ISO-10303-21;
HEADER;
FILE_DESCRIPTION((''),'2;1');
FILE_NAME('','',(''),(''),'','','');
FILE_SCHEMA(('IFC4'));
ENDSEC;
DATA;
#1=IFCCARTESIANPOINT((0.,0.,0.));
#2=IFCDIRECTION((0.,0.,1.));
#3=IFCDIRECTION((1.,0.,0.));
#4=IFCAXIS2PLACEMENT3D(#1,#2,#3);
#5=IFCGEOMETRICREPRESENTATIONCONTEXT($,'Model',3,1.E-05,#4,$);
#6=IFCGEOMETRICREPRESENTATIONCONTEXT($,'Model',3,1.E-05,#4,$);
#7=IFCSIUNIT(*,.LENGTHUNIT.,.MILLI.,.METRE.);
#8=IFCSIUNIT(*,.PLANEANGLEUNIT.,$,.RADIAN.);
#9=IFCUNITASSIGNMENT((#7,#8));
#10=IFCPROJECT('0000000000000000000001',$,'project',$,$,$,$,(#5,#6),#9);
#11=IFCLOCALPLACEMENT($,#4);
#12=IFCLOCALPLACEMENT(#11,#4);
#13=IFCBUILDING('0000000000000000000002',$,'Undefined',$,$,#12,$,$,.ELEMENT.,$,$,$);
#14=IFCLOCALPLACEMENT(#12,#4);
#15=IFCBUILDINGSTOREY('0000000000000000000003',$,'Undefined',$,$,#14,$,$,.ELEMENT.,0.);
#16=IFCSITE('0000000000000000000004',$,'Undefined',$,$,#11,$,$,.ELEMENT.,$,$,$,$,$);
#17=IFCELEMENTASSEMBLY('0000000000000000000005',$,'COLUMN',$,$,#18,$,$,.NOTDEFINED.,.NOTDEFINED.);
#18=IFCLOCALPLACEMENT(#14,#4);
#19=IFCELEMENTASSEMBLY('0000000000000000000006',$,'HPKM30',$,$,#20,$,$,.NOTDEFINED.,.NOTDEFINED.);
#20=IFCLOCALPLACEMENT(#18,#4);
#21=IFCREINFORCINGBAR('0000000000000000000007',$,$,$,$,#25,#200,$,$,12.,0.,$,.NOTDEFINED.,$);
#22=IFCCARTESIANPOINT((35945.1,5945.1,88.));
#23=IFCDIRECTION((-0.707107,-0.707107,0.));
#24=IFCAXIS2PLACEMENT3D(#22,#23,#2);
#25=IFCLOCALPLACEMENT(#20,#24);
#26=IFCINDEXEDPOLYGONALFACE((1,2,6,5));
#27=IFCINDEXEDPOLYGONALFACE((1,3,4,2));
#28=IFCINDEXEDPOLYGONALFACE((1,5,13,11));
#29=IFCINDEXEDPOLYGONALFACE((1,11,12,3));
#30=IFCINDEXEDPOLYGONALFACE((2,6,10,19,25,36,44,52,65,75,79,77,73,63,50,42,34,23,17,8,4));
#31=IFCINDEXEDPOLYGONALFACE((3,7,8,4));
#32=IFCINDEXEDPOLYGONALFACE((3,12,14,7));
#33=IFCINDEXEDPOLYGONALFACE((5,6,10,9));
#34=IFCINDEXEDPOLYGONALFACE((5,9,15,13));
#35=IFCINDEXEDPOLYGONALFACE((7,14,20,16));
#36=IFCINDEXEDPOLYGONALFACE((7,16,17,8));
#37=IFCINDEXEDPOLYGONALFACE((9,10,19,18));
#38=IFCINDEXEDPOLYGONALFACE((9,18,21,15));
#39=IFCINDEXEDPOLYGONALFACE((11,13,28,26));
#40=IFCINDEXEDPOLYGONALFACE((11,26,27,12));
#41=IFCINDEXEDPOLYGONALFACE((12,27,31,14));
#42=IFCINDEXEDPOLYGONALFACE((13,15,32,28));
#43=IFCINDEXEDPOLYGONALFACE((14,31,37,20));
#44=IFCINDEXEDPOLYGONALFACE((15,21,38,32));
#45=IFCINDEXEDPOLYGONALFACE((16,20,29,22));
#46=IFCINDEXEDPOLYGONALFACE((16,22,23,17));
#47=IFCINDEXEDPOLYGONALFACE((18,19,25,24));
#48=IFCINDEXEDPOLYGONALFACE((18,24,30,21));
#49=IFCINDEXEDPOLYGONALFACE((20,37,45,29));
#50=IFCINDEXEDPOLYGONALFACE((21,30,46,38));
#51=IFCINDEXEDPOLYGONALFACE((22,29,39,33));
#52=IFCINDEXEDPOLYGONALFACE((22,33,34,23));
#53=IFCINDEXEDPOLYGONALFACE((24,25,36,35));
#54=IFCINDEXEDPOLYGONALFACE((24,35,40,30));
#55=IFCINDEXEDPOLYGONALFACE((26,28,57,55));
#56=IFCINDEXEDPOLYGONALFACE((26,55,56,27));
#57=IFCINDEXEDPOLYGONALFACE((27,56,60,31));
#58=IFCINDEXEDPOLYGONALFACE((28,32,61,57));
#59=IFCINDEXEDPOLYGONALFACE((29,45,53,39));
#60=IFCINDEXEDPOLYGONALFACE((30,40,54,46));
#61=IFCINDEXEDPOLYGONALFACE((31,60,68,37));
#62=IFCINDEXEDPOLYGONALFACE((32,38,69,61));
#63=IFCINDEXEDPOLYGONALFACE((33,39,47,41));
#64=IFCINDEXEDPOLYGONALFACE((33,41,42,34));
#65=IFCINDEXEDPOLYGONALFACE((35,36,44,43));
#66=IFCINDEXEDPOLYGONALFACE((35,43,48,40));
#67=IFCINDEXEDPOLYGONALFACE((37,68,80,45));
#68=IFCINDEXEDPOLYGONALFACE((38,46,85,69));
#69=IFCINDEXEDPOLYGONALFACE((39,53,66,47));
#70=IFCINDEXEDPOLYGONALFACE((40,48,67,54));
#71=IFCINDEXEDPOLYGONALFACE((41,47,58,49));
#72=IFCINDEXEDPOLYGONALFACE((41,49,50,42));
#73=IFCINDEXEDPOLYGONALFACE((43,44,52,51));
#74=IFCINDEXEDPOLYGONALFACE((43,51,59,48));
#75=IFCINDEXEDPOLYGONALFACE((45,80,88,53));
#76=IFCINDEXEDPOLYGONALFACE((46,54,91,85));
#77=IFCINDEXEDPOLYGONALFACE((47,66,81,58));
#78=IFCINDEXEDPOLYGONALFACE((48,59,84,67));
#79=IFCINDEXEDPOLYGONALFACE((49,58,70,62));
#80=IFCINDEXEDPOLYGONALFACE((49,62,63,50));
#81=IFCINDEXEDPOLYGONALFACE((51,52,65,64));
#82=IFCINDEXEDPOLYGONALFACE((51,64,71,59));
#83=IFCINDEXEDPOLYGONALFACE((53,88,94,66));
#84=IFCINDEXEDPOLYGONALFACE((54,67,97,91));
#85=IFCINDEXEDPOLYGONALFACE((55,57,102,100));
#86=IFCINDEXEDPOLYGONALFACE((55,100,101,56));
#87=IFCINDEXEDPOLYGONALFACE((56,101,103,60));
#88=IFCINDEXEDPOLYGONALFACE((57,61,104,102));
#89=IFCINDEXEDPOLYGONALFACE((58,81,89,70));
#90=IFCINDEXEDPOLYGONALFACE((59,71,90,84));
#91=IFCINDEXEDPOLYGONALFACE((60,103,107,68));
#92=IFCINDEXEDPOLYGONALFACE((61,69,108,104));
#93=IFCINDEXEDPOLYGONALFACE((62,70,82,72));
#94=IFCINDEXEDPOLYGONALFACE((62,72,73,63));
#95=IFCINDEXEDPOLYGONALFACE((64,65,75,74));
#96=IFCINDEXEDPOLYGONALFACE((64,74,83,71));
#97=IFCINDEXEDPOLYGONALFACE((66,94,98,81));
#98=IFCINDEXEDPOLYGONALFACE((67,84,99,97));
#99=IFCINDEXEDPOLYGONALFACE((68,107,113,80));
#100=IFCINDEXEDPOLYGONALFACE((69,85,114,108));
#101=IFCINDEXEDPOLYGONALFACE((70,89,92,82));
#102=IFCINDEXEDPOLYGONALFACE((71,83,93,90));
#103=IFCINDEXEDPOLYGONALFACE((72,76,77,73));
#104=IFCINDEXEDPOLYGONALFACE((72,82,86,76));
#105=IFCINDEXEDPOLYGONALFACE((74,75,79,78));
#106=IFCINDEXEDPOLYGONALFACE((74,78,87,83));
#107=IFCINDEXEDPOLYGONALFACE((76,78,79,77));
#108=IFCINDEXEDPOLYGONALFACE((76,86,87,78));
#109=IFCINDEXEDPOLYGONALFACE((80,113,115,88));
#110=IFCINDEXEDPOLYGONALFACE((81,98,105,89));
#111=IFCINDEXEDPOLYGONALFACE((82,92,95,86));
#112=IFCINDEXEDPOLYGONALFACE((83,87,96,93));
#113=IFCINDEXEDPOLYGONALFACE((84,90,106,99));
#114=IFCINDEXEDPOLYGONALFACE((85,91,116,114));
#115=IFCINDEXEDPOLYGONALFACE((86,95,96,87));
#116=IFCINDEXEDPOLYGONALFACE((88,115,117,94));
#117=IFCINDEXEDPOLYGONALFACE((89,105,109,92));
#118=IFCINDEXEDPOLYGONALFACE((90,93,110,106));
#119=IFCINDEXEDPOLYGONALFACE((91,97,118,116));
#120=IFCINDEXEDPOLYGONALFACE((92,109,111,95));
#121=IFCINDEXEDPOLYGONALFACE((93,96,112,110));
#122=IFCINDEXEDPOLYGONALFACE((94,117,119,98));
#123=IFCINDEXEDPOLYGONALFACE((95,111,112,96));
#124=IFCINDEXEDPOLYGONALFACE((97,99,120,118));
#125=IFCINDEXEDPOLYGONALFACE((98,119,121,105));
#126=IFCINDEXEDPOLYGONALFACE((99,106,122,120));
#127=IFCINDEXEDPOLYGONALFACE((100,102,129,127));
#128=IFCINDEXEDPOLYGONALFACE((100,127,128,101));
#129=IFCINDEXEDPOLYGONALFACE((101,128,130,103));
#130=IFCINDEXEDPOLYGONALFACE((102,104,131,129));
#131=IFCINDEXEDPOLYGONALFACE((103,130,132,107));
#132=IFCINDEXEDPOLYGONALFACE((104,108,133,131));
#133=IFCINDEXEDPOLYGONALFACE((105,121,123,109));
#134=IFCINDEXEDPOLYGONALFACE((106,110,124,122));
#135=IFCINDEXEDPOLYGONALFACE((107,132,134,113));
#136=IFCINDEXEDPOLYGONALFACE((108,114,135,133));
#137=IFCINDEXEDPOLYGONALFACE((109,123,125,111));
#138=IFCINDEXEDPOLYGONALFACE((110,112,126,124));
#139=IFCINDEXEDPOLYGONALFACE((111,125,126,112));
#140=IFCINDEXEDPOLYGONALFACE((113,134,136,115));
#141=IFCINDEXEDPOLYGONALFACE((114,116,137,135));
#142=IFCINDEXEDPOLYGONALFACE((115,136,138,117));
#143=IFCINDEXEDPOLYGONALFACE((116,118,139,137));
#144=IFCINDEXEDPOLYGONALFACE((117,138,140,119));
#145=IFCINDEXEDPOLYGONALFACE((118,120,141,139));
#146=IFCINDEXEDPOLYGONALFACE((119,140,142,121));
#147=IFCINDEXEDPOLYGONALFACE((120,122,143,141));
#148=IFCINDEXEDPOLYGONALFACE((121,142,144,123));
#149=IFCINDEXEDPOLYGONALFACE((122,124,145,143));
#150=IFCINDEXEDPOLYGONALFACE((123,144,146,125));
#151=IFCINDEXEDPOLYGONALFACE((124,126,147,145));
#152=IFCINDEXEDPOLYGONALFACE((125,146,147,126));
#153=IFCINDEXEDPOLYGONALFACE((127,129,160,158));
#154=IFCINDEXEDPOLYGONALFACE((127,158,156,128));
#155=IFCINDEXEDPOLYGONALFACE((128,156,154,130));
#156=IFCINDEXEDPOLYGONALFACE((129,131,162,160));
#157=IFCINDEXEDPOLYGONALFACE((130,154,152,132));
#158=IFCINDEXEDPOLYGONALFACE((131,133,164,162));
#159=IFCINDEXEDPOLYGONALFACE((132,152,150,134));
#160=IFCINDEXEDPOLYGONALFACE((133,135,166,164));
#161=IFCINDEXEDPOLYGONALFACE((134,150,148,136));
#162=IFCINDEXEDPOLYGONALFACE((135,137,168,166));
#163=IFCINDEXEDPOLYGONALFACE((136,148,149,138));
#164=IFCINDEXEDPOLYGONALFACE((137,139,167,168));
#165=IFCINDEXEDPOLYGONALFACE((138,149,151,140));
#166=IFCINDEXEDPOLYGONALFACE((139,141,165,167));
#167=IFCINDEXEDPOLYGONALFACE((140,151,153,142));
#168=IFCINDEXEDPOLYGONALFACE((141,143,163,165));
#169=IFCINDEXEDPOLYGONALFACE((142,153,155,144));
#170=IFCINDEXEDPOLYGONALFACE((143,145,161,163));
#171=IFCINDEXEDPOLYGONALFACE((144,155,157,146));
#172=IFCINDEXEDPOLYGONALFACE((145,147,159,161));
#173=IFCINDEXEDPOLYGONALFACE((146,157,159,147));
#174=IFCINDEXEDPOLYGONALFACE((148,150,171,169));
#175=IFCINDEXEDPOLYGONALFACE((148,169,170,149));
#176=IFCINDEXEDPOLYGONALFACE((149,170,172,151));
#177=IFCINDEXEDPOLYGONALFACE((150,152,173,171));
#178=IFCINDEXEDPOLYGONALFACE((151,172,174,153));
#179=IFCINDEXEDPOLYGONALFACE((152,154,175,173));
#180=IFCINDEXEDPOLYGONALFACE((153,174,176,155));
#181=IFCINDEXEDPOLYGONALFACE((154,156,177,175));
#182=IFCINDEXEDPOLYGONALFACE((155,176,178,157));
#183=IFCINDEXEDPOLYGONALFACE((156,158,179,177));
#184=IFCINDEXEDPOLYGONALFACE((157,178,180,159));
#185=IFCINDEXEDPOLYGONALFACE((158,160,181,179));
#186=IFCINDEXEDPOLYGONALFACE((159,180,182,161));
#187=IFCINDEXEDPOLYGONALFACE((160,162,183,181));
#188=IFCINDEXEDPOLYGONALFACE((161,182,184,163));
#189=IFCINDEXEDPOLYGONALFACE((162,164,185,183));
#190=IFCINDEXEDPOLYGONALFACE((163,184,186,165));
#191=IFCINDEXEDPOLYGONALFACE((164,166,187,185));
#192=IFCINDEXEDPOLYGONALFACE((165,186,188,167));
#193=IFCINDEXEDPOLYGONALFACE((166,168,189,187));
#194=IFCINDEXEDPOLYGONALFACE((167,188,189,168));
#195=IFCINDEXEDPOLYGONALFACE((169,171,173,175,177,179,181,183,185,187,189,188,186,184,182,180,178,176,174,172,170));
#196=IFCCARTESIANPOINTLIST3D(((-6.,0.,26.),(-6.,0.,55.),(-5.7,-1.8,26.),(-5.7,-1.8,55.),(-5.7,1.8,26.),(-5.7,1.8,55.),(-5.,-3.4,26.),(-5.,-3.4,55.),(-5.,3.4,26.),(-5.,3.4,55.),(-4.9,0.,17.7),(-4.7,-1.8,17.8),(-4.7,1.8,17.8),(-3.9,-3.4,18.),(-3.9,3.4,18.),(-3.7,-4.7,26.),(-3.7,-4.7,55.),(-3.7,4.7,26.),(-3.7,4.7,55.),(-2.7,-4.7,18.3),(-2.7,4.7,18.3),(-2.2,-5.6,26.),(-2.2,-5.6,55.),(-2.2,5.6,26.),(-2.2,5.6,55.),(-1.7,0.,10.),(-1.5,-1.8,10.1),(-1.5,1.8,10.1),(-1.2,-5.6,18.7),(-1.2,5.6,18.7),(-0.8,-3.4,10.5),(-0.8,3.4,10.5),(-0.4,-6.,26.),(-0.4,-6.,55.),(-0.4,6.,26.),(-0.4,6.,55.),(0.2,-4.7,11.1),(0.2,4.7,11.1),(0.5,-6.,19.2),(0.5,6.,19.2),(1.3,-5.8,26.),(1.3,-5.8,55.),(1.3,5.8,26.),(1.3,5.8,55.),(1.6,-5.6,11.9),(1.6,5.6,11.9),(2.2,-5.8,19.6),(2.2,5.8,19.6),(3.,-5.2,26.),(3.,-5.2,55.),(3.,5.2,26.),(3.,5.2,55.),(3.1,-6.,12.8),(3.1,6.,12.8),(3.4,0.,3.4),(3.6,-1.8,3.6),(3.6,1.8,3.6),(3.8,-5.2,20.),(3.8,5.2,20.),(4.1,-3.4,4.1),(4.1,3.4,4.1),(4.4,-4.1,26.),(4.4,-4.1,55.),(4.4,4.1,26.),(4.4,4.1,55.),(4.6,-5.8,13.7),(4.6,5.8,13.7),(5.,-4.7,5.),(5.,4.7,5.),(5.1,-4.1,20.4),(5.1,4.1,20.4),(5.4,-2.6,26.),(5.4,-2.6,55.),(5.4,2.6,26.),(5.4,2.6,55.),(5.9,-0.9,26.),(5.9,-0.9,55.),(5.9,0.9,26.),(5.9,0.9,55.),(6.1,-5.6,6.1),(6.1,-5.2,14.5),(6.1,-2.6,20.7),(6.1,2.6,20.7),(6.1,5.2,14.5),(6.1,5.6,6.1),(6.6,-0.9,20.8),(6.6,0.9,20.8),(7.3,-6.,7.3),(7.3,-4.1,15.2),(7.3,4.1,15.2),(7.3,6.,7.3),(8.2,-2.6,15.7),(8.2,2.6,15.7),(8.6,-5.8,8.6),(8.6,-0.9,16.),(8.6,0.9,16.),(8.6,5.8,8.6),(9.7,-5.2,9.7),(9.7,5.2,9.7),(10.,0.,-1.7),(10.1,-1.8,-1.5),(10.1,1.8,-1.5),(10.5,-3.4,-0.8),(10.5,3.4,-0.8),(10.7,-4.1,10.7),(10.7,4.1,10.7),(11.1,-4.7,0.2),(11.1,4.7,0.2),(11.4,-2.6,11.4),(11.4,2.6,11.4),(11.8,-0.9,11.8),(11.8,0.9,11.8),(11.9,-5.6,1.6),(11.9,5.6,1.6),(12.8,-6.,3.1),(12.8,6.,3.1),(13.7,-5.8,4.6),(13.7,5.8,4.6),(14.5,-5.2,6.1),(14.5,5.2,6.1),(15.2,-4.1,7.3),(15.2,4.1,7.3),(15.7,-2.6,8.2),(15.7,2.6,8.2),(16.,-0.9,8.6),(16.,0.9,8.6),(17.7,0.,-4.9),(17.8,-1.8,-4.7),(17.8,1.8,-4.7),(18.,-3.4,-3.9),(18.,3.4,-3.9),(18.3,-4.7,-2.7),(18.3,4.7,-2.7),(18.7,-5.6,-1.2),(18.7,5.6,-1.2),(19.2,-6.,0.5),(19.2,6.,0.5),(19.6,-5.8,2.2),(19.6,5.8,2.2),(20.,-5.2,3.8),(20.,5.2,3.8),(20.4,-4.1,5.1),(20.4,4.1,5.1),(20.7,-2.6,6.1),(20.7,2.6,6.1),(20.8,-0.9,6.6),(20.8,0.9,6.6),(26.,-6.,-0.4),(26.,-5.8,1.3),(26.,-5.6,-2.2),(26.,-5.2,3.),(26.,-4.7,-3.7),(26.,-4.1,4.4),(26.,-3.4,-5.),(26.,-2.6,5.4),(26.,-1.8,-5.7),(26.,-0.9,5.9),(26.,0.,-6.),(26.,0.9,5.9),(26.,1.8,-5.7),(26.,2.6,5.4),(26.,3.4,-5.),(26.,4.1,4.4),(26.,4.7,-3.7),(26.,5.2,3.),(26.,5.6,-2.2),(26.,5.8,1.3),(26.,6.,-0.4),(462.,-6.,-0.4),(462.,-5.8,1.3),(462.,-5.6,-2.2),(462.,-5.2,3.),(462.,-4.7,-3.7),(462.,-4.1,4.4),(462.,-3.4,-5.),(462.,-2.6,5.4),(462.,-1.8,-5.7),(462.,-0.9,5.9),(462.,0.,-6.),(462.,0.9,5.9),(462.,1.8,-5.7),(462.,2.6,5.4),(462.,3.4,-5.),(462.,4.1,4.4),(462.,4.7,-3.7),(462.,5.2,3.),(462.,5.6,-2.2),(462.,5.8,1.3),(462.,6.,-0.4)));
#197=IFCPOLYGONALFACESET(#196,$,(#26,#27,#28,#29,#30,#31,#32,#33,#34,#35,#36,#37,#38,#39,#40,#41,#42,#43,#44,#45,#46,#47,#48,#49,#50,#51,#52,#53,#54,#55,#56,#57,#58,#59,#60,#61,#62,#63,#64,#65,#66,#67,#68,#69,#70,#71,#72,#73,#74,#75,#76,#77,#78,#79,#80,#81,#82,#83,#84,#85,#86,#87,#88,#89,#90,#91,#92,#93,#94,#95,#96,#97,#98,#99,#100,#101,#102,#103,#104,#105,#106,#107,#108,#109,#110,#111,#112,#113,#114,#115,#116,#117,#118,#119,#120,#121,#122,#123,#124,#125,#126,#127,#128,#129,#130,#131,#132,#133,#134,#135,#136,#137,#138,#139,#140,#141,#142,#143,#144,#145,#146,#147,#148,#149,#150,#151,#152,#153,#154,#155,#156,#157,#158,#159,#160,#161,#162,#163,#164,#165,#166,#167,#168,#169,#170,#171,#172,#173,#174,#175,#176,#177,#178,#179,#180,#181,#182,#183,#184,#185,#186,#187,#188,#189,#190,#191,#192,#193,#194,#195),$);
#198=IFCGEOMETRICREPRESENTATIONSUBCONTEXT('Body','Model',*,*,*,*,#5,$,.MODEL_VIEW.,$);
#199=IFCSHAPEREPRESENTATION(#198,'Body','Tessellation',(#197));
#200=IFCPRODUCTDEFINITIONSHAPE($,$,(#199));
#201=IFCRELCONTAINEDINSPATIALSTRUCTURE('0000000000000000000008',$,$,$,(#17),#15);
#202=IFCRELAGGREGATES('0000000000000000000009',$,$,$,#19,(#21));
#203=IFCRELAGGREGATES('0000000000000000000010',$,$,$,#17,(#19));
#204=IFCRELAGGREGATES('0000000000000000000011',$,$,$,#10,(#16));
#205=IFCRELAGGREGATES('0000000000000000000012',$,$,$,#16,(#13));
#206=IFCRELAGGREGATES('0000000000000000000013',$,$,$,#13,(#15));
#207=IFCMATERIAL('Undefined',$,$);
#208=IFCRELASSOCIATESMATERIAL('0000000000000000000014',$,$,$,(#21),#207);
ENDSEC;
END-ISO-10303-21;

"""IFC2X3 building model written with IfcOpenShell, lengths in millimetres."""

from ifc_helpers import new_model, entity, si_unit, frame, origin_with_axes, place, context, subcontext, project, spatial, source, transform, mapped, material, element, aggregate, save


model = new_model("IFC2X3")

# Units and contexts
model_context_1 = context("Model", 3, precision=1e-05, world=origin_with_axes())
model_context_2 = context("Model", 3, precision=1e-05, world=origin_with_axes())
body_context = subcontext(model_context_1, "Body", "Model", "MODEL_VIEW")
ifc_project = project(units=[si_unit("LENGTHUNIT", "METRE", prefix="MILLI"), si_unit("PLANEANGLEUNIT", "RADIAN")], contexts=[model_context_1, model_context_2])

# Site, building, storey
site_placement = place(None, origin_with_axes())
site = spatial("IfcSite", under=ifc_project, at=site_placement, Name="Undefined", CompositionType="ELEMENT")
building_placement = place(site_placement, origin_with_axes())
building = spatial("IfcBuilding", under=site, at=building_placement, Name="Undefined", CompositionType="ELEMENT")
storey_placement = place(building_placement, origin_with_axes())
storey = spatial("IfcBuildingStorey", under=building, at=storey_placement, Name="Undefined", CompositionType="ELEMENT", Elevation=0.0)

# Element assembly
assembly_1_placement = place(storey_placement, origin_with_axes())
assembly_1 = element("IfcElementAssembly", 1, at=assembly_1_placement, inside=storey, Name="COLUMN", AssemblyPlace="NOTDEFINED", PredefinedType="NOTDEFINED")

# Element assembly
assembly_2_placement = place(assembly_1_placement, origin_with_axes())
assembly_2 = element("IfcElementAssembly", 2, at=assembly_2_placement, Name="HPKM30", AssemblyPlace="NOTDEFINED", PredefinedType="NOTDEFINED")

# Shared definitions
ifc_material_1 = material(Name="Undefined")

# Reinforcing bar
shared_shape_1 = source(origin_with_axes(), body_context, "Body", "AdvancedSweptSolid", [
    entity("IfcSweptDiskSolid", entity("IfcCompositeCurve", [entity("IfcCompositeCurveSegment", "CONTINUOUS", True, entity("IfcTrimmedCurve", entity("IfcLine", entity("IfcCartesianPoint", [0.0, 0.0, 0.0]), entity("IfcVector", entity("IfcDirection", [0.0, 0.0, -1.0]), 1.0)), [entity("IfcParameterValue", 0.0)], [entity("IfcParameterValue", 29.0)], True, "PARAMETER")), entity("IfcCompositeCurveSegment", "CONTINUOUS", True, entity("IfcTrimmedCurve", entity("IfcCircle", entity("IfcAxis2Placement3D", entity("IfcCartesianPoint", [26.0, 0.0, -29.0]), entity("IfcDirection", [0.0, -1.0, 0.0]), entity("IfcDirection", [-1.0, 0.0, 0.0])), 26.0), [entity("IfcParameterValue", 0.0)], [entity("IfcParameterValue", 1.570796)], True, "PARAMETER")), entity("IfcCompositeCurveSegment", "DISCONTINUOUS", True, entity("IfcTrimmedCurve", entity("IfcLine", entity("IfcCartesianPoint", [26.0, 0.0, -55.0]), entity("IfcVector", entity("IfcDirection", [1.0, 0.0, 0.0]), 1.0)), [entity("IfcParameterValue", 0.0)], [entity("IfcParameterValue", 436.0)], True, "PARAMETER"))], False), 6.0, None, 0.0, 466.6),
])
reinforcing_bar_1_placement = place(assembly_2_placement, frame((35945.1, 5945.1, 88.0), z_axis=(-0.707107, -0.707107, 0.0), x_axis=(0.0, 0.0, 1.0)))
reinforcing_bar_1 = element("IfcReinforcingBar", 3, at=reinforcing_bar_1_placement, material=ifc_material_1, BarRole="NOTDEFINED", CrossSectionArea=0.0, NominalDiameter=12.0, context=body_context, shape_type="MappedRepresentation", body=[
    mapped(shared_shape_1, transform((0.0, 0.0, 55.0))),
])
aggregate(assembly_2, [reinforcing_bar_1])
aggregate(assembly_1, [assembly_2])

save(model, "model.ifc")
